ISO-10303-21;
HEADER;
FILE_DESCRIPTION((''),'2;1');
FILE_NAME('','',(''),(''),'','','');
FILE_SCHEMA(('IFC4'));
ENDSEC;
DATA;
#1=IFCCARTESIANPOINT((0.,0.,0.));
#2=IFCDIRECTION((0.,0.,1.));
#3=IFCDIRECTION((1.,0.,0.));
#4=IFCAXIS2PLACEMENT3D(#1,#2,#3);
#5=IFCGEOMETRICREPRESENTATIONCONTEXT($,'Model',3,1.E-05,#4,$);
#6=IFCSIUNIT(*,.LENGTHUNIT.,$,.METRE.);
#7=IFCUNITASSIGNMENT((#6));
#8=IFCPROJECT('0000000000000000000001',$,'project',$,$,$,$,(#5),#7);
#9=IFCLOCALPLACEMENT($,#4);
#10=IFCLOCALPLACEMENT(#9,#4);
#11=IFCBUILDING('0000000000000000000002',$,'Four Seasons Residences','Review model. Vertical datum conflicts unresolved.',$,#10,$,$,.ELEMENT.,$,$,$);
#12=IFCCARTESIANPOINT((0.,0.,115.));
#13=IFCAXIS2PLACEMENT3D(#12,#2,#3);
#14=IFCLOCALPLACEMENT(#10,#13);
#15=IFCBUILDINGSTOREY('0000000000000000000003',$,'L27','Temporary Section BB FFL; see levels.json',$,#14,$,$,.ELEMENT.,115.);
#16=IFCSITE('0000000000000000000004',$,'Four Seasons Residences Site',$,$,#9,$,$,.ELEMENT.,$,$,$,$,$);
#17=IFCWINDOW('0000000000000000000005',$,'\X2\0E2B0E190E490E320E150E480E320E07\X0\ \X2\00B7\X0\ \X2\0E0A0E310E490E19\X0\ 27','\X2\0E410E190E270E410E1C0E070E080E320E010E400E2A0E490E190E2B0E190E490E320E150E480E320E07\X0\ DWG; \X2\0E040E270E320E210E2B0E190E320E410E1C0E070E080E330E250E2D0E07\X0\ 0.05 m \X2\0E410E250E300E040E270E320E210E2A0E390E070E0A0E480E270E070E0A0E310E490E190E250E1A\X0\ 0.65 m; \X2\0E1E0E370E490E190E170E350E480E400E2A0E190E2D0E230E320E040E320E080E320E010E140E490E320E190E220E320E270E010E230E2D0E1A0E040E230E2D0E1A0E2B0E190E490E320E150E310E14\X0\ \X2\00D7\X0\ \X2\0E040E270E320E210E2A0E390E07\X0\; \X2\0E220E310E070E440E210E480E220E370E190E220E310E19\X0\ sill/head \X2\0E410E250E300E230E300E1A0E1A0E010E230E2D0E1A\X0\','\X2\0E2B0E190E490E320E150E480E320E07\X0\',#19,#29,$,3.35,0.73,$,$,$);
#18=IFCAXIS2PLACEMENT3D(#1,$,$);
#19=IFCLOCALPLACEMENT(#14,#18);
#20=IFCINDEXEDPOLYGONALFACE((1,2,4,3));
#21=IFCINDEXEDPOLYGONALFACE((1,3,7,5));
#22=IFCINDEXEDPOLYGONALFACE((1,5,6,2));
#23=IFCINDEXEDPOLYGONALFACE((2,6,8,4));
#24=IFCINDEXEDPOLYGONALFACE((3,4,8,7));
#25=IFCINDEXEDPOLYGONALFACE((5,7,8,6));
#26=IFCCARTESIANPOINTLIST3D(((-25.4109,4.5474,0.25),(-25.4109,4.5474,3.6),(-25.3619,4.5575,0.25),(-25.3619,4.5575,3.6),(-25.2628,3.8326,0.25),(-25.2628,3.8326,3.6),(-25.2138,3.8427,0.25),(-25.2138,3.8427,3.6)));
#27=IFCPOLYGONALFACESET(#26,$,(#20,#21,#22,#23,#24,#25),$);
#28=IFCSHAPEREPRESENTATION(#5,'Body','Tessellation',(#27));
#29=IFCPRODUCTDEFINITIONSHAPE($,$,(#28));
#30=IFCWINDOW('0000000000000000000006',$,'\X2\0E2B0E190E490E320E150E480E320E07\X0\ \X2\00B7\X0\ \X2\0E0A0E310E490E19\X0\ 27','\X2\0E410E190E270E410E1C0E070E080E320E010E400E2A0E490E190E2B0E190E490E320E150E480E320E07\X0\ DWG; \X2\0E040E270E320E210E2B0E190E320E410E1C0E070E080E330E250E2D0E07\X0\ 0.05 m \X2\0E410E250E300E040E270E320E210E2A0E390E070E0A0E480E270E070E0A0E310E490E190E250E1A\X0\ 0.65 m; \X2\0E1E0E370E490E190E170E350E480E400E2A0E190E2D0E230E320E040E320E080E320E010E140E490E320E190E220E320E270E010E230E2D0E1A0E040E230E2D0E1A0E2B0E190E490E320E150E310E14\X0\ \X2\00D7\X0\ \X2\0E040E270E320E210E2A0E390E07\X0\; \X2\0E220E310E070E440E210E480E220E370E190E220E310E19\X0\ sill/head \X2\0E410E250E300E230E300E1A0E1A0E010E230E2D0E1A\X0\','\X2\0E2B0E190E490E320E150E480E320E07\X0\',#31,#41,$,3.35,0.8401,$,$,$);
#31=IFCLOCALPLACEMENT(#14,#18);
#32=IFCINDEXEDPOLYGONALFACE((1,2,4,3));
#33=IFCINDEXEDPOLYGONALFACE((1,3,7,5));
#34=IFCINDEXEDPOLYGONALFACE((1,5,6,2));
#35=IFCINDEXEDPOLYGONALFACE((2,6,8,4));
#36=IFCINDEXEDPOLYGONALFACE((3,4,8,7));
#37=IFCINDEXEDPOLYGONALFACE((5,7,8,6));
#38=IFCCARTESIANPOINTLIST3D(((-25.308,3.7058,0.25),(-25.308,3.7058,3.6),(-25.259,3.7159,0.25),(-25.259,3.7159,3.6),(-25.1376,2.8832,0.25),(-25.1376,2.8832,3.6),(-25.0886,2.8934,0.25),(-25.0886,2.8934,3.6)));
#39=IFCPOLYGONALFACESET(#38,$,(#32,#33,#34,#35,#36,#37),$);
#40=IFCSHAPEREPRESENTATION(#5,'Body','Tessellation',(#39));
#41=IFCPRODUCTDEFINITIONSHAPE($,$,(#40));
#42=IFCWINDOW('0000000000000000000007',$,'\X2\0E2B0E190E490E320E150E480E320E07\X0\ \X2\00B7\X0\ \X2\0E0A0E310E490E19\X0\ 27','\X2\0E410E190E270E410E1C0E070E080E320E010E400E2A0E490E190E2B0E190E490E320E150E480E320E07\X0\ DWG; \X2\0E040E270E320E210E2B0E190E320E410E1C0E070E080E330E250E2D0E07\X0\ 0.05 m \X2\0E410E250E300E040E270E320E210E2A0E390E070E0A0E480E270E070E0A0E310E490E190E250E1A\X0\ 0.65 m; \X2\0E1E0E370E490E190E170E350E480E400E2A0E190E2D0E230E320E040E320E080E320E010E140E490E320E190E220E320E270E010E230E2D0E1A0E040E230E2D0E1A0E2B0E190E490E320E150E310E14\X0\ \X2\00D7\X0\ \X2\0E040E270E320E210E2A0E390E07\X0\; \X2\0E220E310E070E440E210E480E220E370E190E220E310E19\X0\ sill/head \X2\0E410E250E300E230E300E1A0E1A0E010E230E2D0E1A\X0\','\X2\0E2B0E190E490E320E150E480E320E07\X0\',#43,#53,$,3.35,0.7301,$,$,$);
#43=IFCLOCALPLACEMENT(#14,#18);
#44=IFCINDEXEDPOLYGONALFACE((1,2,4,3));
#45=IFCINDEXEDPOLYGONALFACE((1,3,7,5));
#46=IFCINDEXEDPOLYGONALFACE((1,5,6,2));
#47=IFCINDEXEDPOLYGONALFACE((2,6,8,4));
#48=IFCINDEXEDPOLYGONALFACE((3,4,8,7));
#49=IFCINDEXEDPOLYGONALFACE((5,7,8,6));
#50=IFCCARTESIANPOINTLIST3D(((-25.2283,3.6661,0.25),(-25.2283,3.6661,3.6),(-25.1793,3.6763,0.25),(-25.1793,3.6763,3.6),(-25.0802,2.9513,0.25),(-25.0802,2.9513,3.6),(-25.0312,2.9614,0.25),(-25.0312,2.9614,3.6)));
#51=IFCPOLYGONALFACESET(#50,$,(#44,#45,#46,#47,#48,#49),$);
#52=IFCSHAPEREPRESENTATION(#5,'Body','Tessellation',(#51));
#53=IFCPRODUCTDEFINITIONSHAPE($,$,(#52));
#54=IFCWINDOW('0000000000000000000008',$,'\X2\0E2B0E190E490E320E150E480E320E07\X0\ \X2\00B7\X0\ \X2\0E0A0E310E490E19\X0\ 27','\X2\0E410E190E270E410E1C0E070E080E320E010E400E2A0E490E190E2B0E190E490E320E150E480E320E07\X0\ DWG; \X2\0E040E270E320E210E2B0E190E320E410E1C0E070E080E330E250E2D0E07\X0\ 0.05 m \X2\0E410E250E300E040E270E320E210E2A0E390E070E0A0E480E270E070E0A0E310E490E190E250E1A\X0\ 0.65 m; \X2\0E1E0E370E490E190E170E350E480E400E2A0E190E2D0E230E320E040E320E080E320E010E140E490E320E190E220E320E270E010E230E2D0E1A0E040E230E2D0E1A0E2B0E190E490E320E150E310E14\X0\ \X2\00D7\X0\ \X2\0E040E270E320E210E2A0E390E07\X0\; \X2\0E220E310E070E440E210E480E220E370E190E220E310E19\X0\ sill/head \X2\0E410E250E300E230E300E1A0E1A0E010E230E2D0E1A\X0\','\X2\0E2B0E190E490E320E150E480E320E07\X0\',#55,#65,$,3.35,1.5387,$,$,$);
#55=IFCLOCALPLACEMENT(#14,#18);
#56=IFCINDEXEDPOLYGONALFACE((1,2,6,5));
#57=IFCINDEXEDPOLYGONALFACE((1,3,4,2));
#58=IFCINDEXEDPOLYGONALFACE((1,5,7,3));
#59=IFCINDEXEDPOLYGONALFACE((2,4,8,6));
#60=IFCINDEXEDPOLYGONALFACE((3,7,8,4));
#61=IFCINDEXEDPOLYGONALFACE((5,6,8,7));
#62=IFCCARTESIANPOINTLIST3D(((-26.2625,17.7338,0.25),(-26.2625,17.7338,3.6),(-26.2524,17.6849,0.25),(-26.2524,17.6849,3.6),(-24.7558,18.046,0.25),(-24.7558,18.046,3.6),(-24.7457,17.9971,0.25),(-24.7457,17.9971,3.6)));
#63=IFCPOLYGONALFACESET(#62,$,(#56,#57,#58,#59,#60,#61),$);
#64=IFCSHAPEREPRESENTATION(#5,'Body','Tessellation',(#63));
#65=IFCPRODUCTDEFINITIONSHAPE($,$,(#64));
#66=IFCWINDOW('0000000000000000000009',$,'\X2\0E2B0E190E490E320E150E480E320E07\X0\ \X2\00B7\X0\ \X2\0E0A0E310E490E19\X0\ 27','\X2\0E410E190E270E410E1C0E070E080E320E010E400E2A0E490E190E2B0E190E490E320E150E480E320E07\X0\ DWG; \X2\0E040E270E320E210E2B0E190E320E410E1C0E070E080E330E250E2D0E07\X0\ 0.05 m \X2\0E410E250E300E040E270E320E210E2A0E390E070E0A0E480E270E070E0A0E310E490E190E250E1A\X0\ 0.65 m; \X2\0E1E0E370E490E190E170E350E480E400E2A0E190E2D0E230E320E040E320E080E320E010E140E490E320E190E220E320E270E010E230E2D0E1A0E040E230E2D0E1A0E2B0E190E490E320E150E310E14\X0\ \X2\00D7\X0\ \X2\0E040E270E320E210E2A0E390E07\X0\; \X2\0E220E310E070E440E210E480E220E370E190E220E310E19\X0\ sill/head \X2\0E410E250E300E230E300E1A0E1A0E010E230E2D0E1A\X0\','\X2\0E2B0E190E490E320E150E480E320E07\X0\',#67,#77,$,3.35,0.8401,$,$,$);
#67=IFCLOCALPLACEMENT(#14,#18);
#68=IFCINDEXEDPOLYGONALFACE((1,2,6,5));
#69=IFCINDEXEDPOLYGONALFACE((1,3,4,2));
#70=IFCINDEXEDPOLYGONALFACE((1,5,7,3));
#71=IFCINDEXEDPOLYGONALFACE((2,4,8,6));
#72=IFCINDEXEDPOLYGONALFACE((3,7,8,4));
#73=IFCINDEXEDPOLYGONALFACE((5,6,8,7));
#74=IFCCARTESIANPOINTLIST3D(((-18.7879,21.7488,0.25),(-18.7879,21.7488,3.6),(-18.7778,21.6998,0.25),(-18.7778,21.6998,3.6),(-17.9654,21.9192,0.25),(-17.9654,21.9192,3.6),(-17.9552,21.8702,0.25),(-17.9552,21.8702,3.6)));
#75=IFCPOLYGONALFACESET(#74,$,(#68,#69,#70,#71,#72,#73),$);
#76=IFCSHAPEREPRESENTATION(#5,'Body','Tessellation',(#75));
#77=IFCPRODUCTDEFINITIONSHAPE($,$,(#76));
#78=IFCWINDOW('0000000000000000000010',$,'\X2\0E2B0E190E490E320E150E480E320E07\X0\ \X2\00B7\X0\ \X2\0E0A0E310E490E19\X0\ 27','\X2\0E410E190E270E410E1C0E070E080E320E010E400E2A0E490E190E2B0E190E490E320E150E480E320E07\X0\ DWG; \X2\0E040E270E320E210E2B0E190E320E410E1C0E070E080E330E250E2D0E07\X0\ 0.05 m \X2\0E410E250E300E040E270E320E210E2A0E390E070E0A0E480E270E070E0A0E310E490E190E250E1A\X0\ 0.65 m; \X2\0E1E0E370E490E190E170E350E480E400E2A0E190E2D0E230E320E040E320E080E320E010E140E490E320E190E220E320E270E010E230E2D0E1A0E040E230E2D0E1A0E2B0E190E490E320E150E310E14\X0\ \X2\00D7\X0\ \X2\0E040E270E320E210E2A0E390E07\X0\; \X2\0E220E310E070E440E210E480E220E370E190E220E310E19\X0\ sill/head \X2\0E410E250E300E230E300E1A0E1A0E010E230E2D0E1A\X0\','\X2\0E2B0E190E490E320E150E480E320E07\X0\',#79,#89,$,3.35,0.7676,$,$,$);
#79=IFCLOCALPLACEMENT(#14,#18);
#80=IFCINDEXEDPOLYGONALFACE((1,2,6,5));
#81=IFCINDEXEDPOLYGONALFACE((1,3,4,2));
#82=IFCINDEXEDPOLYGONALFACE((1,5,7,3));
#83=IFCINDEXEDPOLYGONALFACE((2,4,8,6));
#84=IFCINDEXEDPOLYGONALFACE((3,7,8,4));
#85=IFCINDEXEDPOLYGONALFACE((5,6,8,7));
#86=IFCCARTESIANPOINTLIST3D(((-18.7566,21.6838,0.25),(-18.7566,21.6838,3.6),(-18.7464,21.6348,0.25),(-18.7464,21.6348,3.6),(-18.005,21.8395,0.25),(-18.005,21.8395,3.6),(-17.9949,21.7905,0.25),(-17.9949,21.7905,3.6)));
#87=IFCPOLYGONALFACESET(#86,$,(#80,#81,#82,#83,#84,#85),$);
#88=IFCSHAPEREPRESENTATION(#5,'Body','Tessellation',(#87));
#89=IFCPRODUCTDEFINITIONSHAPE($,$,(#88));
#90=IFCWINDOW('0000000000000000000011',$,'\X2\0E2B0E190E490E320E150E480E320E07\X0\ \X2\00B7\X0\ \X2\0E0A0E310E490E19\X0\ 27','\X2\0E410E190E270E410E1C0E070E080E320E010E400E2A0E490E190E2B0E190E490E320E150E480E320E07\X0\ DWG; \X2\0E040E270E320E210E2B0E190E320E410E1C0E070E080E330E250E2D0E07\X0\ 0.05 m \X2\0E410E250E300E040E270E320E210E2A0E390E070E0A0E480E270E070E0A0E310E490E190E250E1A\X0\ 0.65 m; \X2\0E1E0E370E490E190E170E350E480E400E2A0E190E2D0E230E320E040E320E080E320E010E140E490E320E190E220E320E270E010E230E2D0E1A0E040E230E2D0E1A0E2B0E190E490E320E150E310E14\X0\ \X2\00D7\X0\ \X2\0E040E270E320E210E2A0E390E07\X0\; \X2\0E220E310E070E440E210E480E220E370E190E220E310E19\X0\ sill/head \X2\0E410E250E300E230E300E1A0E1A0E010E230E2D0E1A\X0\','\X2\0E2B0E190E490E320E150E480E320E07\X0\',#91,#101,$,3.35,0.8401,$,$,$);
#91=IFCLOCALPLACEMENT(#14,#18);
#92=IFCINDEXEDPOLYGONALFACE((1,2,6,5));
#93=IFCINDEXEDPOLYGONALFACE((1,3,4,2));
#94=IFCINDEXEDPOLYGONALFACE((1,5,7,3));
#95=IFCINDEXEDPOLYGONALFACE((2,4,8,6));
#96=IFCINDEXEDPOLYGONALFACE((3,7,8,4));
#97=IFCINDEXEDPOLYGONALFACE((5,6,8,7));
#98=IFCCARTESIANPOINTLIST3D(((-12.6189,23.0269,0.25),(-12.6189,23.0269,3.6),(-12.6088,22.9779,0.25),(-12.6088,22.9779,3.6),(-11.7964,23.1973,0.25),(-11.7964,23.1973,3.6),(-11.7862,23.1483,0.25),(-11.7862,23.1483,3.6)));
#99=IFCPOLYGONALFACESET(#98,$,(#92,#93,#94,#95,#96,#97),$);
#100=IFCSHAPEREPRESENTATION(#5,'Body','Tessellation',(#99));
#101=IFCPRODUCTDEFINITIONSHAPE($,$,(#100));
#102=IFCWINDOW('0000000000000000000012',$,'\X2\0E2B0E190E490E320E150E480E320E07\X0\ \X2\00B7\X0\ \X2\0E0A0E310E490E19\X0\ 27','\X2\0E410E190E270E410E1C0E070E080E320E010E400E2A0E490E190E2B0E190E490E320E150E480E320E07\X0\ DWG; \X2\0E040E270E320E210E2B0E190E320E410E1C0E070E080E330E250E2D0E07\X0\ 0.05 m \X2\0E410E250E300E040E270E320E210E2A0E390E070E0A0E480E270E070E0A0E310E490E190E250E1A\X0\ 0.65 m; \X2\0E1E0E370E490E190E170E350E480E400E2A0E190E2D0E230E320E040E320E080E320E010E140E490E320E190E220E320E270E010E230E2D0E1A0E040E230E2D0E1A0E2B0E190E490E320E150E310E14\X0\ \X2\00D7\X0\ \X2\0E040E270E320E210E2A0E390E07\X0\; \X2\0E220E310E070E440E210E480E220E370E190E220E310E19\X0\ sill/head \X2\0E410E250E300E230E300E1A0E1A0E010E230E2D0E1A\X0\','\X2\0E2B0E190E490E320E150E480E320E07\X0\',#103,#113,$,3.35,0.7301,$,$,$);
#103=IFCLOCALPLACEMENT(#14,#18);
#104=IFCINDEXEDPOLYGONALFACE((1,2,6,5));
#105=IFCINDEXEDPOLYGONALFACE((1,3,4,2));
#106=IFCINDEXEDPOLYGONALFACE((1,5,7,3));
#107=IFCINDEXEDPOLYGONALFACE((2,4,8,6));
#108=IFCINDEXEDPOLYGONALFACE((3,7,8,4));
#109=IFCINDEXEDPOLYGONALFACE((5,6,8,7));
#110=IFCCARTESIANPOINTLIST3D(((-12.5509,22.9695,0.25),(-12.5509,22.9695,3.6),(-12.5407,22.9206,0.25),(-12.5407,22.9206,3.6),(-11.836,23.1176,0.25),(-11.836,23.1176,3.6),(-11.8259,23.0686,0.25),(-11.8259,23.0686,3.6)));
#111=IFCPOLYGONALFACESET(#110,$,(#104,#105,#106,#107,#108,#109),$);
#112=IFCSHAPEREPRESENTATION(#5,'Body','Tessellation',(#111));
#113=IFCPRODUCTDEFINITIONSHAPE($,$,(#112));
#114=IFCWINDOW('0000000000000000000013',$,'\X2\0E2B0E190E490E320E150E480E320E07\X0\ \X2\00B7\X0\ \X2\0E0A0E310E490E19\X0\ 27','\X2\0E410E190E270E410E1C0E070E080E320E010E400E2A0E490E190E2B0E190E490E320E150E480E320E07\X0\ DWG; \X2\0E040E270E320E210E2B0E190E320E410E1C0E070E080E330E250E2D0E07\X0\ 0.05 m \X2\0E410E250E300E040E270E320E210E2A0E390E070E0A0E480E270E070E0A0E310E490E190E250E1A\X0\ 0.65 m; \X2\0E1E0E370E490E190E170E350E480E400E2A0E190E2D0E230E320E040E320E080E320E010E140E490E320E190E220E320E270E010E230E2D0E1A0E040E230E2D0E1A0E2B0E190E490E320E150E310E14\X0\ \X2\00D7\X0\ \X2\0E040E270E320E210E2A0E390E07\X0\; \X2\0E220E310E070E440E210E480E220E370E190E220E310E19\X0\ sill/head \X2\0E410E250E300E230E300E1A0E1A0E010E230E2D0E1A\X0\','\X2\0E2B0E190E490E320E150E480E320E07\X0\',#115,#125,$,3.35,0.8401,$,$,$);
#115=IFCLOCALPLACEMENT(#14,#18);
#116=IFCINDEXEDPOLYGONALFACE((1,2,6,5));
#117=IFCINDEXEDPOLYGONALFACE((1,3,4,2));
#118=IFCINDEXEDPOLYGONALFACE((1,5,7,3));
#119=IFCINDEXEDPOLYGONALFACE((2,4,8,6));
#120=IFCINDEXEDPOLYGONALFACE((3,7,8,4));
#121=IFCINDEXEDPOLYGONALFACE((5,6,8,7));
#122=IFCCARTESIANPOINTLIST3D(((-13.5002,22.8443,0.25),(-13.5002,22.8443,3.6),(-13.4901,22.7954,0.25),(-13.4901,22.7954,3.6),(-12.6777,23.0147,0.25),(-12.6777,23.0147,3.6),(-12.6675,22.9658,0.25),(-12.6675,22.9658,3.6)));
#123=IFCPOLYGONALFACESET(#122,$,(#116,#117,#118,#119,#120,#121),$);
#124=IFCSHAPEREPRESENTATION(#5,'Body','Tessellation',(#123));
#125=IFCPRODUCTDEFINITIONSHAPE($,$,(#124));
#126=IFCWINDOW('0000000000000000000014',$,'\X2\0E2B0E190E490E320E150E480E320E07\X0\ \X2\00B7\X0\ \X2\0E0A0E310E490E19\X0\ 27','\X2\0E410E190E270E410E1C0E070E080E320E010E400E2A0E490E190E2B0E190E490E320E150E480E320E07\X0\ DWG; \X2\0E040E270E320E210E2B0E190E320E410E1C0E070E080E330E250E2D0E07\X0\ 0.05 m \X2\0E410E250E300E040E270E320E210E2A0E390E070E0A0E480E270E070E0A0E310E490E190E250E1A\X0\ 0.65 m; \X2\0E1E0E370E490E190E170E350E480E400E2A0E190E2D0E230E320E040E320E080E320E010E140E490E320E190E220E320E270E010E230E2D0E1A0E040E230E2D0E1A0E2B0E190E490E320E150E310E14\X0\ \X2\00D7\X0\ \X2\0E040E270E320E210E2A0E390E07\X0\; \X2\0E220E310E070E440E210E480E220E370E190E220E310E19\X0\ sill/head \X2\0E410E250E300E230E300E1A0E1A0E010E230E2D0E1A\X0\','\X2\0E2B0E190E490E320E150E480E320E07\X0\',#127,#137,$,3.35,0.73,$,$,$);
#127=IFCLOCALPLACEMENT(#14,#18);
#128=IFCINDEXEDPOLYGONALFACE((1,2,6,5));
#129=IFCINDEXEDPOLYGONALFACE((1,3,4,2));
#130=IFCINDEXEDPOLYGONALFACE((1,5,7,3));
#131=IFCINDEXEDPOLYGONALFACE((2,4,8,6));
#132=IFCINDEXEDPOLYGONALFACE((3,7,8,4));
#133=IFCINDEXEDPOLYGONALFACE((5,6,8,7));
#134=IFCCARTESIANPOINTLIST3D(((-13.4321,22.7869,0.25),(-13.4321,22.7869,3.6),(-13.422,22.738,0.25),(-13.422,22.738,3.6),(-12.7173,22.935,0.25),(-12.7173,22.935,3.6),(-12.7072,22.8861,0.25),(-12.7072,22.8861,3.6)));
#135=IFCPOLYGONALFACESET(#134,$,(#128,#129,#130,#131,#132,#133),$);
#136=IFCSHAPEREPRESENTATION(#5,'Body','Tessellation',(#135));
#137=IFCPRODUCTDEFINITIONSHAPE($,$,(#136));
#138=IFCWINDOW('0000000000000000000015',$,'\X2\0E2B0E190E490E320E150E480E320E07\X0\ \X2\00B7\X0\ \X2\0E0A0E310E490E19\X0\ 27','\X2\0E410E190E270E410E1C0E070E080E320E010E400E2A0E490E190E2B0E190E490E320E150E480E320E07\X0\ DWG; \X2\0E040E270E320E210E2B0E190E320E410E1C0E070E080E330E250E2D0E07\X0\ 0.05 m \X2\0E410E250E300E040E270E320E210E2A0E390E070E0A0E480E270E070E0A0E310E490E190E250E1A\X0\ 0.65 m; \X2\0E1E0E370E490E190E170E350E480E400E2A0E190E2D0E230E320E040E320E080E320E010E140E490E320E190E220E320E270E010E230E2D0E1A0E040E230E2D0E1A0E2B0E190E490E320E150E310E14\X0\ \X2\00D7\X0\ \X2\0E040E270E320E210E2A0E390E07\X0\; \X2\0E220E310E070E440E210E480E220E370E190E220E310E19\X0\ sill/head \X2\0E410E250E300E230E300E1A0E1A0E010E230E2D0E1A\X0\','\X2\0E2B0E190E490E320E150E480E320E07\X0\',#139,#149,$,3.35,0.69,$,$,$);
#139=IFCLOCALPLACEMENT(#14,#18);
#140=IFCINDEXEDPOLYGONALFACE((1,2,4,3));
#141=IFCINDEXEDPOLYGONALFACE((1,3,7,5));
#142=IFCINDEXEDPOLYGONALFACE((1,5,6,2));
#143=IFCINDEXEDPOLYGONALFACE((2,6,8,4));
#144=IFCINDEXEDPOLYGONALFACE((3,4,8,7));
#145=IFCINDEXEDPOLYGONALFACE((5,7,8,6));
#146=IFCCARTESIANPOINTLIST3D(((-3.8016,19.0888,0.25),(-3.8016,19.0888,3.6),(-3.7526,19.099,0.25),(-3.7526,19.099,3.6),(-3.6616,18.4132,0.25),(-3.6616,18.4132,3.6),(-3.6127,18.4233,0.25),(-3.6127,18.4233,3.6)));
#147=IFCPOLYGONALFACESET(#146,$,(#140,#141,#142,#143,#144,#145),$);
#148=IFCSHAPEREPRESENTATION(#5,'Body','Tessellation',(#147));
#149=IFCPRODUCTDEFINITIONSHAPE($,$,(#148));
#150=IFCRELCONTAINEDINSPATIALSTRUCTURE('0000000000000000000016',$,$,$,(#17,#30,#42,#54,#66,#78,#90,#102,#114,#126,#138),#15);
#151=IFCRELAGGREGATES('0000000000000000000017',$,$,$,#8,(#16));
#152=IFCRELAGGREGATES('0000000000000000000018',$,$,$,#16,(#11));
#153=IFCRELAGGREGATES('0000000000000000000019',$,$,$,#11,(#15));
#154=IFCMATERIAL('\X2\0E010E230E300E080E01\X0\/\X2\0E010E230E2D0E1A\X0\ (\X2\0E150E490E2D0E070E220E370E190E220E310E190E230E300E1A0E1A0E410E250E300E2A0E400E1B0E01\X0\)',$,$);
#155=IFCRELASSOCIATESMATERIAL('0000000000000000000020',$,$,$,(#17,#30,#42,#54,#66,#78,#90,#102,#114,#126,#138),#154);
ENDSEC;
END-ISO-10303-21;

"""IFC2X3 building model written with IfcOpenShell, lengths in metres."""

from ifc_helpers import new_model, si_unit, frame, origin_with_axes, place, context, project, spatial, polyline, outline, extrude, material, element, save


model = new_model("IFC2X3")

# Units and contexts
model_context = context("Model", 3, precision=1e-05, world=origin_with_axes())
ifc_project = project(units=[si_unit("LENGTHUNIT", "METRE")], contexts=[model_context])

# Site, building, storey
site_placement = place(None, origin_with_axes())
site = spatial("IfcSite", under=ifc_project, at=site_placement, Name="Four Seasons Residences Site", CompositionType="ELEMENT")
building_placement = place(site_placement, origin_with_axes())
building = spatial("IfcBuilding", under=site, at=building_placement, Name="Four Seasons Residences", Description="Review model. Vertical datum conflicts unresolved.", CompositionType="ELEMENT")
storey_placement = place(building_placement, frame((0.0, 0.0, 115.0), z_axis=(0.0, 0.0, 1.0), x_axis=(1.0, 0.0, 0.0)))
storey = spatial("IfcBuildingStorey", under=building, at=storey_placement, Name="L27", Description="Temporary Section BB FFL; see levels.json", CompositionType="ELEMENT", Elevation=115.0)

# Windows
ifc_material = material(Name="กระจก/กรอบ (ต้องยืนยันระบบและสเปก)")
window_1_placement = place(storey_placement, origin_with_axes())
element("IfcWindow", 1, at=window_1_placement, inside=storey, material=ifc_material, Name="หน้าต่าง · ชั้น 27", Description="แนวแผงจากเส้นหน้าต่าง DWG; ความหนาแผงจำลอง 0.05 m และความสูงช่วงชั้นลบ 0.65 m; พื้นที่เสนอราคาจากด้านยาวกรอบครอบหน้าตัด × ความสูง; ยังไม่ยืนยัน sill/head และระบบกรอบ", ObjectType="หน้าต่าง", OverallHeight=3.35, OverallWidth=0.73, context=model_context, shape_type="SweptSolid", body=[
    extrude(outline(polyline([(-25.2138, 3.8427), (-25.2628, 3.8326), (-25.4109, 4.5474), (-25.3619, 4.5575), (-25.2138, 3.8427)])), frame((0.0, 0.0, 0.25), z_axis=(0.0, 0.0, 1.0), x_axis=(1.0, 0.0, 0.0)), (0.0, 0.0, 1.0), 3.35),
])
window_2_placement = place(storey_placement, origin_with_axes())
element("IfcWindow", 2, at=window_2_placement, inside=storey, material=ifc_material, Name="หน้าต่าง · ชั้น 27", Description="แนวแผงจากเส้นหน้าต่าง DWG; ความหนาแผงจำลอง 0.05 m และความสูงช่วงชั้นลบ 0.65 m; พื้นที่เสนอราคาจากด้านยาวกรอบครอบหน้าตัด × ความสูง; ยังไม่ยืนยัน sill/head และระบบกรอบ", ObjectType="หน้าต่าง", OverallHeight=3.35, OverallWidth=0.8401, context=model_context, shape_type="SweptSolid", body=[
    extrude(outline(polyline([(-25.0886, 2.8934), (-25.1376, 2.8832), (-25.308, 3.7058), (-25.259, 3.7159), (-25.0886, 2.8934)])), frame((0.0, 0.0, 0.25), z_axis=(0.0, 0.0, 1.0), x_axis=(1.0, 0.0, 0.0)), (0.0, 0.0, 1.0), 3.35),
])
window_3_placement = place(storey_placement, origin_with_axes())
element("IfcWindow", 3, at=window_3_placement, inside=storey, material=ifc_material, Name="หน้าต่าง · ชั้น 27", Description="แนวแผงจากเส้นหน้าต่าง DWG; ความหนาแผงจำลอง 0.05 m และความสูงช่วงชั้นลบ 0.65 m; พื้นที่เสนอราคาจากด้านยาวกรอบครอบหน้าตัด × ความสูง; ยังไม่ยืนยัน sill/head และระบบกรอบ", ObjectType="หน้าต่าง", OverallHeight=3.35, OverallWidth=0.7301, context=model_context, shape_type="SweptSolid", body=[
    extrude(outline(polyline([(-25.0312, 2.9614), (-25.0802, 2.9513), (-25.2283, 3.6661), (-25.1793, 3.6763), (-25.0312, 2.9614)])), frame((0.0, 0.0, 0.25), z_axis=(0.0, 0.0, 1.0), x_axis=(1.0, 0.0, 0.0)), (0.0, 0.0, 1.0), 3.35),
])
window_4_placement = place(storey_placement, origin_with_axes())
element("IfcWindow", 4, at=window_4_placement, inside=storey, material=ifc_material, Name="หน้าต่าง · ชั้น 27", Description="แนวแผงจากเส้นหน้าต่าง DWG; ความหนาแผงจำลอง 0.05 m และความสูงช่วงชั้นลบ 0.65 m; พื้นที่เสนอราคาจากด้านยาวกรอบครอบหน้าตัด × ความสูง; ยังไม่ยืนยัน sill/head และระบบกรอบ", ObjectType="หน้าต่าง", OverallHeight=3.35, OverallWidth=1.5387, context=model_context, shape_type="SweptSolid", body=[
    extrude(outline(polyline([(-26.2524, 17.6849), (-26.2625, 17.7338), (-24.7558, 18.046), (-24.7457, 17.9971), (-26.2524, 17.6849)])), frame((0.0, 0.0, 0.25), z_axis=(0.0, 0.0, 1.0), x_axis=(1.0, 0.0, 0.0)), (0.0, 0.0, 1.0), 3.35),
])
window_5_placement = place(storey_placement, origin_with_axes())
element("IfcWindow", 5, at=window_5_placement, inside=storey, material=ifc_material, Name="หน้าต่าง · ชั้น 27", Description="แนวแผงจากเส้นหน้าต่าง DWG; ความหนาแผงจำลอง 0.05 m และความสูงช่วงชั้นลบ 0.65 m; พื้นที่เสนอราคาจากด้านยาวกรอบครอบหน้าตัด × ความสูง; ยังไม่ยืนยัน sill/head และระบบกรอบ", ObjectType="หน้าต่าง", OverallHeight=3.35, OverallWidth=0.8401, context=model_context, shape_type="SweptSolid", body=[
    extrude(outline(polyline([(-17.9654, 21.9192), (-17.9552, 21.8702), (-18.7778, 21.6998), (-18.7879, 21.7488), (-17.9654, 21.9192)])), frame((0.0, 0.0, 0.25), z_axis=(0.0, 0.0, 1.0), x_axis=(1.0, 0.0, 0.0)), (0.0, 0.0, 1.0), 3.35),
])
window_6_placement = place(storey_placement, origin_with_axes())
element("IfcWindow", 6, at=window_6_placement, inside=storey, material=ifc_material, Name="หน้าต่าง · ชั้น 27", Description="แนวแผงจากเส้นหน้าต่าง DWG; ความหนาแผงจำลอง 0.05 m และความสูงช่วงชั้นลบ 0.65 m; พื้นที่เสนอราคาจากด้านยาวกรอบครอบหน้าตัด × ความสูง; ยังไม่ยืนยัน sill/head และระบบกรอบ", ObjectType="หน้าต่าง", OverallHeight=3.35, OverallWidth=0.7676, context=model_context, shape_type="SweptSolid", body=[
    extrude(outline(polyline([(-18.005, 21.8395), (-17.9949, 21.7905), (-18.7464, 21.6348), (-18.7566, 21.6838), (-18.005, 21.8395)])), frame((0.0, 0.0, 0.25), z_axis=(0.0, 0.0, 1.0), x_axis=(1.0, 0.0, 0.0)), (0.0, 0.0, 1.0), 3.35),
])
window_7_placement = place(storey_placement, origin_with_axes())
element("IfcWindow", 7, at=window_7_placement, inside=storey, material=ifc_material, Name="หน้าต่าง · ชั้น 27", Description="แนวแผงจากเส้นหน้าต่าง DWG; ความหนาแผงจำลอง 0.05 m และความสูงช่วงชั้นลบ 0.65 m; พื้นที่เสนอราคาจากด้านยาวกรอบครอบหน้าตัด × ความสูง; ยังไม่ยืนยัน sill/head และระบบกรอบ", ObjectType="หน้าต่าง", OverallHeight=3.35, OverallWidth=0.8401, context=model_context, shape_type="SweptSolid", body=[
    extrude(outline(polyline([(-12.6088, 22.9779), (-12.6189, 23.0269), (-11.7964, 23.1973), (-11.7862, 23.1483), (-12.6088, 22.9779)])), frame((0.0, 0.0, 0.25), z_axis=(0.0, 0.0, 1.0), x_axis=(1.0, 0.0, 0.0)), (0.0, 0.0, 1.0), 3.35),
])
window_8_placement = place(storey_placement, origin_with_axes())
element("IfcWindow", 8, at=window_8_placement, inside=storey, material=ifc_material, Name="หน้าต่าง · ชั้น 27", Description="แนวแผงจากเส้นหน้าต่าง DWG; ความหนาแผงจำลอง 0.05 m และความสูงช่วงชั้นลบ 0.65 m; พื้นที่เสนอราคาจากด้านยาวกรอบครอบหน้าตัด × ความสูง; ยังไม่ยืนยัน sill/head และระบบกรอบ", ObjectType="หน้าต่าง", OverallHeight=3.35, OverallWidth=0.7301, context=model_context, shape_type="SweptSolid", body=[
    extrude(outline(polyline([(-12.5407, 22.9206), (-12.5509, 22.9695), (-11.836, 23.1176), (-11.8259, 23.0686), (-12.5407, 22.9206)])), frame((0.0, 0.0, 0.25), z_axis=(0.0, 0.0, 1.0), x_axis=(1.0, 0.0, 0.0)), (0.0, 0.0, 1.0), 3.35),
])
window_9_placement = place(storey_placement, origin_with_axes())
element("IfcWindow", 9, at=window_9_placement, inside=storey, material=ifc_material, Name="หน้าต่าง · ชั้น 27", Description="แนวแผงจากเส้นหน้าต่าง DWG; ความหนาแผงจำลอง 0.05 m และความสูงช่วงชั้นลบ 0.65 m; พื้นที่เสนอราคาจากด้านยาวกรอบครอบหน้าตัด × ความสูง; ยังไม่ยืนยัน sill/head และระบบกรอบ", ObjectType="หน้าต่าง", OverallHeight=3.35, OverallWidth=0.8401, context=model_context, shape_type="SweptSolid", body=[
    extrude(outline(polyline([(-13.4901, 22.7954), (-13.5002, 22.8443), (-12.6777, 23.0147), (-12.6675, 22.9658), (-13.4901, 22.7954)])), frame((0.0, 0.0, 0.25), z_axis=(0.0, 0.0, 1.0), x_axis=(1.0, 0.0, 0.0)), (0.0, 0.0, 1.0), 3.35),
])
window_10_placement = place(storey_placement, origin_with_axes())
element("IfcWindow", 10, at=window_10_placement, inside=storey, material=ifc_material, Name="หน้าต่าง · ชั้น 27", Description="แนวแผงจากเส้นหน้าต่าง DWG; ความหนาแผงจำลอง 0.05 m และความสูงช่วงชั้นลบ 0.65 m; พื้นที่เสนอราคาจากด้านยาวกรอบครอบหน้าตัด × ความสูง; ยังไม่ยืนยัน sill/head และระบบกรอบ", ObjectType="หน้าต่าง", OverallHeight=3.35, OverallWidth=0.73, context=model_context, shape_type="SweptSolid", body=[
    extrude(outline(polyline([(-13.422, 22.738), (-13.4321, 22.7869), (-12.7173, 22.935), (-12.7072, 22.8861), (-13.422, 22.738)])), frame((0.0, 0.0, 0.25), z_axis=(0.0, 0.0, 1.0), x_axis=(1.0, 0.0, 0.0)), (0.0, 0.0, 1.0), 3.35),
])
window_11_placement = place(storey_placement, origin_with_axes())
element("IfcWindow", 11, at=window_11_placement, inside=storey, material=ifc_material, Name="หน้าต่าง · ชั้น 27", Description="แนวแผงจากเส้นหน้าต่าง DWG; ความหนาแผงจำลอง 0.05 m และความสูงช่วงชั้นลบ 0.65 m; พื้นที่เสนอราคาจากด้านยาวกรอบครอบหน้าตัด × ความสูง; ยังไม่ยืนยัน sill/head และระบบกรอบ", ObjectType="หน้าต่าง", OverallHeight=3.35, OverallWidth=0.69, context=model_context, shape_type="SweptSolid", body=[
    extrude(outline(polyline([(-3.6127, 18.4233), (-3.6616, 18.4132), (-3.8016, 19.0888), (-3.7526, 19.099), (-3.6127, 18.4233)])), frame((0.0, 0.0, 0.25), z_axis=(0.0, 0.0, 1.0), x_axis=(1.0, 0.0, 0.0)), (0.0, 0.0, 1.0), 3.35),
])

save(model, "model.ifc")
